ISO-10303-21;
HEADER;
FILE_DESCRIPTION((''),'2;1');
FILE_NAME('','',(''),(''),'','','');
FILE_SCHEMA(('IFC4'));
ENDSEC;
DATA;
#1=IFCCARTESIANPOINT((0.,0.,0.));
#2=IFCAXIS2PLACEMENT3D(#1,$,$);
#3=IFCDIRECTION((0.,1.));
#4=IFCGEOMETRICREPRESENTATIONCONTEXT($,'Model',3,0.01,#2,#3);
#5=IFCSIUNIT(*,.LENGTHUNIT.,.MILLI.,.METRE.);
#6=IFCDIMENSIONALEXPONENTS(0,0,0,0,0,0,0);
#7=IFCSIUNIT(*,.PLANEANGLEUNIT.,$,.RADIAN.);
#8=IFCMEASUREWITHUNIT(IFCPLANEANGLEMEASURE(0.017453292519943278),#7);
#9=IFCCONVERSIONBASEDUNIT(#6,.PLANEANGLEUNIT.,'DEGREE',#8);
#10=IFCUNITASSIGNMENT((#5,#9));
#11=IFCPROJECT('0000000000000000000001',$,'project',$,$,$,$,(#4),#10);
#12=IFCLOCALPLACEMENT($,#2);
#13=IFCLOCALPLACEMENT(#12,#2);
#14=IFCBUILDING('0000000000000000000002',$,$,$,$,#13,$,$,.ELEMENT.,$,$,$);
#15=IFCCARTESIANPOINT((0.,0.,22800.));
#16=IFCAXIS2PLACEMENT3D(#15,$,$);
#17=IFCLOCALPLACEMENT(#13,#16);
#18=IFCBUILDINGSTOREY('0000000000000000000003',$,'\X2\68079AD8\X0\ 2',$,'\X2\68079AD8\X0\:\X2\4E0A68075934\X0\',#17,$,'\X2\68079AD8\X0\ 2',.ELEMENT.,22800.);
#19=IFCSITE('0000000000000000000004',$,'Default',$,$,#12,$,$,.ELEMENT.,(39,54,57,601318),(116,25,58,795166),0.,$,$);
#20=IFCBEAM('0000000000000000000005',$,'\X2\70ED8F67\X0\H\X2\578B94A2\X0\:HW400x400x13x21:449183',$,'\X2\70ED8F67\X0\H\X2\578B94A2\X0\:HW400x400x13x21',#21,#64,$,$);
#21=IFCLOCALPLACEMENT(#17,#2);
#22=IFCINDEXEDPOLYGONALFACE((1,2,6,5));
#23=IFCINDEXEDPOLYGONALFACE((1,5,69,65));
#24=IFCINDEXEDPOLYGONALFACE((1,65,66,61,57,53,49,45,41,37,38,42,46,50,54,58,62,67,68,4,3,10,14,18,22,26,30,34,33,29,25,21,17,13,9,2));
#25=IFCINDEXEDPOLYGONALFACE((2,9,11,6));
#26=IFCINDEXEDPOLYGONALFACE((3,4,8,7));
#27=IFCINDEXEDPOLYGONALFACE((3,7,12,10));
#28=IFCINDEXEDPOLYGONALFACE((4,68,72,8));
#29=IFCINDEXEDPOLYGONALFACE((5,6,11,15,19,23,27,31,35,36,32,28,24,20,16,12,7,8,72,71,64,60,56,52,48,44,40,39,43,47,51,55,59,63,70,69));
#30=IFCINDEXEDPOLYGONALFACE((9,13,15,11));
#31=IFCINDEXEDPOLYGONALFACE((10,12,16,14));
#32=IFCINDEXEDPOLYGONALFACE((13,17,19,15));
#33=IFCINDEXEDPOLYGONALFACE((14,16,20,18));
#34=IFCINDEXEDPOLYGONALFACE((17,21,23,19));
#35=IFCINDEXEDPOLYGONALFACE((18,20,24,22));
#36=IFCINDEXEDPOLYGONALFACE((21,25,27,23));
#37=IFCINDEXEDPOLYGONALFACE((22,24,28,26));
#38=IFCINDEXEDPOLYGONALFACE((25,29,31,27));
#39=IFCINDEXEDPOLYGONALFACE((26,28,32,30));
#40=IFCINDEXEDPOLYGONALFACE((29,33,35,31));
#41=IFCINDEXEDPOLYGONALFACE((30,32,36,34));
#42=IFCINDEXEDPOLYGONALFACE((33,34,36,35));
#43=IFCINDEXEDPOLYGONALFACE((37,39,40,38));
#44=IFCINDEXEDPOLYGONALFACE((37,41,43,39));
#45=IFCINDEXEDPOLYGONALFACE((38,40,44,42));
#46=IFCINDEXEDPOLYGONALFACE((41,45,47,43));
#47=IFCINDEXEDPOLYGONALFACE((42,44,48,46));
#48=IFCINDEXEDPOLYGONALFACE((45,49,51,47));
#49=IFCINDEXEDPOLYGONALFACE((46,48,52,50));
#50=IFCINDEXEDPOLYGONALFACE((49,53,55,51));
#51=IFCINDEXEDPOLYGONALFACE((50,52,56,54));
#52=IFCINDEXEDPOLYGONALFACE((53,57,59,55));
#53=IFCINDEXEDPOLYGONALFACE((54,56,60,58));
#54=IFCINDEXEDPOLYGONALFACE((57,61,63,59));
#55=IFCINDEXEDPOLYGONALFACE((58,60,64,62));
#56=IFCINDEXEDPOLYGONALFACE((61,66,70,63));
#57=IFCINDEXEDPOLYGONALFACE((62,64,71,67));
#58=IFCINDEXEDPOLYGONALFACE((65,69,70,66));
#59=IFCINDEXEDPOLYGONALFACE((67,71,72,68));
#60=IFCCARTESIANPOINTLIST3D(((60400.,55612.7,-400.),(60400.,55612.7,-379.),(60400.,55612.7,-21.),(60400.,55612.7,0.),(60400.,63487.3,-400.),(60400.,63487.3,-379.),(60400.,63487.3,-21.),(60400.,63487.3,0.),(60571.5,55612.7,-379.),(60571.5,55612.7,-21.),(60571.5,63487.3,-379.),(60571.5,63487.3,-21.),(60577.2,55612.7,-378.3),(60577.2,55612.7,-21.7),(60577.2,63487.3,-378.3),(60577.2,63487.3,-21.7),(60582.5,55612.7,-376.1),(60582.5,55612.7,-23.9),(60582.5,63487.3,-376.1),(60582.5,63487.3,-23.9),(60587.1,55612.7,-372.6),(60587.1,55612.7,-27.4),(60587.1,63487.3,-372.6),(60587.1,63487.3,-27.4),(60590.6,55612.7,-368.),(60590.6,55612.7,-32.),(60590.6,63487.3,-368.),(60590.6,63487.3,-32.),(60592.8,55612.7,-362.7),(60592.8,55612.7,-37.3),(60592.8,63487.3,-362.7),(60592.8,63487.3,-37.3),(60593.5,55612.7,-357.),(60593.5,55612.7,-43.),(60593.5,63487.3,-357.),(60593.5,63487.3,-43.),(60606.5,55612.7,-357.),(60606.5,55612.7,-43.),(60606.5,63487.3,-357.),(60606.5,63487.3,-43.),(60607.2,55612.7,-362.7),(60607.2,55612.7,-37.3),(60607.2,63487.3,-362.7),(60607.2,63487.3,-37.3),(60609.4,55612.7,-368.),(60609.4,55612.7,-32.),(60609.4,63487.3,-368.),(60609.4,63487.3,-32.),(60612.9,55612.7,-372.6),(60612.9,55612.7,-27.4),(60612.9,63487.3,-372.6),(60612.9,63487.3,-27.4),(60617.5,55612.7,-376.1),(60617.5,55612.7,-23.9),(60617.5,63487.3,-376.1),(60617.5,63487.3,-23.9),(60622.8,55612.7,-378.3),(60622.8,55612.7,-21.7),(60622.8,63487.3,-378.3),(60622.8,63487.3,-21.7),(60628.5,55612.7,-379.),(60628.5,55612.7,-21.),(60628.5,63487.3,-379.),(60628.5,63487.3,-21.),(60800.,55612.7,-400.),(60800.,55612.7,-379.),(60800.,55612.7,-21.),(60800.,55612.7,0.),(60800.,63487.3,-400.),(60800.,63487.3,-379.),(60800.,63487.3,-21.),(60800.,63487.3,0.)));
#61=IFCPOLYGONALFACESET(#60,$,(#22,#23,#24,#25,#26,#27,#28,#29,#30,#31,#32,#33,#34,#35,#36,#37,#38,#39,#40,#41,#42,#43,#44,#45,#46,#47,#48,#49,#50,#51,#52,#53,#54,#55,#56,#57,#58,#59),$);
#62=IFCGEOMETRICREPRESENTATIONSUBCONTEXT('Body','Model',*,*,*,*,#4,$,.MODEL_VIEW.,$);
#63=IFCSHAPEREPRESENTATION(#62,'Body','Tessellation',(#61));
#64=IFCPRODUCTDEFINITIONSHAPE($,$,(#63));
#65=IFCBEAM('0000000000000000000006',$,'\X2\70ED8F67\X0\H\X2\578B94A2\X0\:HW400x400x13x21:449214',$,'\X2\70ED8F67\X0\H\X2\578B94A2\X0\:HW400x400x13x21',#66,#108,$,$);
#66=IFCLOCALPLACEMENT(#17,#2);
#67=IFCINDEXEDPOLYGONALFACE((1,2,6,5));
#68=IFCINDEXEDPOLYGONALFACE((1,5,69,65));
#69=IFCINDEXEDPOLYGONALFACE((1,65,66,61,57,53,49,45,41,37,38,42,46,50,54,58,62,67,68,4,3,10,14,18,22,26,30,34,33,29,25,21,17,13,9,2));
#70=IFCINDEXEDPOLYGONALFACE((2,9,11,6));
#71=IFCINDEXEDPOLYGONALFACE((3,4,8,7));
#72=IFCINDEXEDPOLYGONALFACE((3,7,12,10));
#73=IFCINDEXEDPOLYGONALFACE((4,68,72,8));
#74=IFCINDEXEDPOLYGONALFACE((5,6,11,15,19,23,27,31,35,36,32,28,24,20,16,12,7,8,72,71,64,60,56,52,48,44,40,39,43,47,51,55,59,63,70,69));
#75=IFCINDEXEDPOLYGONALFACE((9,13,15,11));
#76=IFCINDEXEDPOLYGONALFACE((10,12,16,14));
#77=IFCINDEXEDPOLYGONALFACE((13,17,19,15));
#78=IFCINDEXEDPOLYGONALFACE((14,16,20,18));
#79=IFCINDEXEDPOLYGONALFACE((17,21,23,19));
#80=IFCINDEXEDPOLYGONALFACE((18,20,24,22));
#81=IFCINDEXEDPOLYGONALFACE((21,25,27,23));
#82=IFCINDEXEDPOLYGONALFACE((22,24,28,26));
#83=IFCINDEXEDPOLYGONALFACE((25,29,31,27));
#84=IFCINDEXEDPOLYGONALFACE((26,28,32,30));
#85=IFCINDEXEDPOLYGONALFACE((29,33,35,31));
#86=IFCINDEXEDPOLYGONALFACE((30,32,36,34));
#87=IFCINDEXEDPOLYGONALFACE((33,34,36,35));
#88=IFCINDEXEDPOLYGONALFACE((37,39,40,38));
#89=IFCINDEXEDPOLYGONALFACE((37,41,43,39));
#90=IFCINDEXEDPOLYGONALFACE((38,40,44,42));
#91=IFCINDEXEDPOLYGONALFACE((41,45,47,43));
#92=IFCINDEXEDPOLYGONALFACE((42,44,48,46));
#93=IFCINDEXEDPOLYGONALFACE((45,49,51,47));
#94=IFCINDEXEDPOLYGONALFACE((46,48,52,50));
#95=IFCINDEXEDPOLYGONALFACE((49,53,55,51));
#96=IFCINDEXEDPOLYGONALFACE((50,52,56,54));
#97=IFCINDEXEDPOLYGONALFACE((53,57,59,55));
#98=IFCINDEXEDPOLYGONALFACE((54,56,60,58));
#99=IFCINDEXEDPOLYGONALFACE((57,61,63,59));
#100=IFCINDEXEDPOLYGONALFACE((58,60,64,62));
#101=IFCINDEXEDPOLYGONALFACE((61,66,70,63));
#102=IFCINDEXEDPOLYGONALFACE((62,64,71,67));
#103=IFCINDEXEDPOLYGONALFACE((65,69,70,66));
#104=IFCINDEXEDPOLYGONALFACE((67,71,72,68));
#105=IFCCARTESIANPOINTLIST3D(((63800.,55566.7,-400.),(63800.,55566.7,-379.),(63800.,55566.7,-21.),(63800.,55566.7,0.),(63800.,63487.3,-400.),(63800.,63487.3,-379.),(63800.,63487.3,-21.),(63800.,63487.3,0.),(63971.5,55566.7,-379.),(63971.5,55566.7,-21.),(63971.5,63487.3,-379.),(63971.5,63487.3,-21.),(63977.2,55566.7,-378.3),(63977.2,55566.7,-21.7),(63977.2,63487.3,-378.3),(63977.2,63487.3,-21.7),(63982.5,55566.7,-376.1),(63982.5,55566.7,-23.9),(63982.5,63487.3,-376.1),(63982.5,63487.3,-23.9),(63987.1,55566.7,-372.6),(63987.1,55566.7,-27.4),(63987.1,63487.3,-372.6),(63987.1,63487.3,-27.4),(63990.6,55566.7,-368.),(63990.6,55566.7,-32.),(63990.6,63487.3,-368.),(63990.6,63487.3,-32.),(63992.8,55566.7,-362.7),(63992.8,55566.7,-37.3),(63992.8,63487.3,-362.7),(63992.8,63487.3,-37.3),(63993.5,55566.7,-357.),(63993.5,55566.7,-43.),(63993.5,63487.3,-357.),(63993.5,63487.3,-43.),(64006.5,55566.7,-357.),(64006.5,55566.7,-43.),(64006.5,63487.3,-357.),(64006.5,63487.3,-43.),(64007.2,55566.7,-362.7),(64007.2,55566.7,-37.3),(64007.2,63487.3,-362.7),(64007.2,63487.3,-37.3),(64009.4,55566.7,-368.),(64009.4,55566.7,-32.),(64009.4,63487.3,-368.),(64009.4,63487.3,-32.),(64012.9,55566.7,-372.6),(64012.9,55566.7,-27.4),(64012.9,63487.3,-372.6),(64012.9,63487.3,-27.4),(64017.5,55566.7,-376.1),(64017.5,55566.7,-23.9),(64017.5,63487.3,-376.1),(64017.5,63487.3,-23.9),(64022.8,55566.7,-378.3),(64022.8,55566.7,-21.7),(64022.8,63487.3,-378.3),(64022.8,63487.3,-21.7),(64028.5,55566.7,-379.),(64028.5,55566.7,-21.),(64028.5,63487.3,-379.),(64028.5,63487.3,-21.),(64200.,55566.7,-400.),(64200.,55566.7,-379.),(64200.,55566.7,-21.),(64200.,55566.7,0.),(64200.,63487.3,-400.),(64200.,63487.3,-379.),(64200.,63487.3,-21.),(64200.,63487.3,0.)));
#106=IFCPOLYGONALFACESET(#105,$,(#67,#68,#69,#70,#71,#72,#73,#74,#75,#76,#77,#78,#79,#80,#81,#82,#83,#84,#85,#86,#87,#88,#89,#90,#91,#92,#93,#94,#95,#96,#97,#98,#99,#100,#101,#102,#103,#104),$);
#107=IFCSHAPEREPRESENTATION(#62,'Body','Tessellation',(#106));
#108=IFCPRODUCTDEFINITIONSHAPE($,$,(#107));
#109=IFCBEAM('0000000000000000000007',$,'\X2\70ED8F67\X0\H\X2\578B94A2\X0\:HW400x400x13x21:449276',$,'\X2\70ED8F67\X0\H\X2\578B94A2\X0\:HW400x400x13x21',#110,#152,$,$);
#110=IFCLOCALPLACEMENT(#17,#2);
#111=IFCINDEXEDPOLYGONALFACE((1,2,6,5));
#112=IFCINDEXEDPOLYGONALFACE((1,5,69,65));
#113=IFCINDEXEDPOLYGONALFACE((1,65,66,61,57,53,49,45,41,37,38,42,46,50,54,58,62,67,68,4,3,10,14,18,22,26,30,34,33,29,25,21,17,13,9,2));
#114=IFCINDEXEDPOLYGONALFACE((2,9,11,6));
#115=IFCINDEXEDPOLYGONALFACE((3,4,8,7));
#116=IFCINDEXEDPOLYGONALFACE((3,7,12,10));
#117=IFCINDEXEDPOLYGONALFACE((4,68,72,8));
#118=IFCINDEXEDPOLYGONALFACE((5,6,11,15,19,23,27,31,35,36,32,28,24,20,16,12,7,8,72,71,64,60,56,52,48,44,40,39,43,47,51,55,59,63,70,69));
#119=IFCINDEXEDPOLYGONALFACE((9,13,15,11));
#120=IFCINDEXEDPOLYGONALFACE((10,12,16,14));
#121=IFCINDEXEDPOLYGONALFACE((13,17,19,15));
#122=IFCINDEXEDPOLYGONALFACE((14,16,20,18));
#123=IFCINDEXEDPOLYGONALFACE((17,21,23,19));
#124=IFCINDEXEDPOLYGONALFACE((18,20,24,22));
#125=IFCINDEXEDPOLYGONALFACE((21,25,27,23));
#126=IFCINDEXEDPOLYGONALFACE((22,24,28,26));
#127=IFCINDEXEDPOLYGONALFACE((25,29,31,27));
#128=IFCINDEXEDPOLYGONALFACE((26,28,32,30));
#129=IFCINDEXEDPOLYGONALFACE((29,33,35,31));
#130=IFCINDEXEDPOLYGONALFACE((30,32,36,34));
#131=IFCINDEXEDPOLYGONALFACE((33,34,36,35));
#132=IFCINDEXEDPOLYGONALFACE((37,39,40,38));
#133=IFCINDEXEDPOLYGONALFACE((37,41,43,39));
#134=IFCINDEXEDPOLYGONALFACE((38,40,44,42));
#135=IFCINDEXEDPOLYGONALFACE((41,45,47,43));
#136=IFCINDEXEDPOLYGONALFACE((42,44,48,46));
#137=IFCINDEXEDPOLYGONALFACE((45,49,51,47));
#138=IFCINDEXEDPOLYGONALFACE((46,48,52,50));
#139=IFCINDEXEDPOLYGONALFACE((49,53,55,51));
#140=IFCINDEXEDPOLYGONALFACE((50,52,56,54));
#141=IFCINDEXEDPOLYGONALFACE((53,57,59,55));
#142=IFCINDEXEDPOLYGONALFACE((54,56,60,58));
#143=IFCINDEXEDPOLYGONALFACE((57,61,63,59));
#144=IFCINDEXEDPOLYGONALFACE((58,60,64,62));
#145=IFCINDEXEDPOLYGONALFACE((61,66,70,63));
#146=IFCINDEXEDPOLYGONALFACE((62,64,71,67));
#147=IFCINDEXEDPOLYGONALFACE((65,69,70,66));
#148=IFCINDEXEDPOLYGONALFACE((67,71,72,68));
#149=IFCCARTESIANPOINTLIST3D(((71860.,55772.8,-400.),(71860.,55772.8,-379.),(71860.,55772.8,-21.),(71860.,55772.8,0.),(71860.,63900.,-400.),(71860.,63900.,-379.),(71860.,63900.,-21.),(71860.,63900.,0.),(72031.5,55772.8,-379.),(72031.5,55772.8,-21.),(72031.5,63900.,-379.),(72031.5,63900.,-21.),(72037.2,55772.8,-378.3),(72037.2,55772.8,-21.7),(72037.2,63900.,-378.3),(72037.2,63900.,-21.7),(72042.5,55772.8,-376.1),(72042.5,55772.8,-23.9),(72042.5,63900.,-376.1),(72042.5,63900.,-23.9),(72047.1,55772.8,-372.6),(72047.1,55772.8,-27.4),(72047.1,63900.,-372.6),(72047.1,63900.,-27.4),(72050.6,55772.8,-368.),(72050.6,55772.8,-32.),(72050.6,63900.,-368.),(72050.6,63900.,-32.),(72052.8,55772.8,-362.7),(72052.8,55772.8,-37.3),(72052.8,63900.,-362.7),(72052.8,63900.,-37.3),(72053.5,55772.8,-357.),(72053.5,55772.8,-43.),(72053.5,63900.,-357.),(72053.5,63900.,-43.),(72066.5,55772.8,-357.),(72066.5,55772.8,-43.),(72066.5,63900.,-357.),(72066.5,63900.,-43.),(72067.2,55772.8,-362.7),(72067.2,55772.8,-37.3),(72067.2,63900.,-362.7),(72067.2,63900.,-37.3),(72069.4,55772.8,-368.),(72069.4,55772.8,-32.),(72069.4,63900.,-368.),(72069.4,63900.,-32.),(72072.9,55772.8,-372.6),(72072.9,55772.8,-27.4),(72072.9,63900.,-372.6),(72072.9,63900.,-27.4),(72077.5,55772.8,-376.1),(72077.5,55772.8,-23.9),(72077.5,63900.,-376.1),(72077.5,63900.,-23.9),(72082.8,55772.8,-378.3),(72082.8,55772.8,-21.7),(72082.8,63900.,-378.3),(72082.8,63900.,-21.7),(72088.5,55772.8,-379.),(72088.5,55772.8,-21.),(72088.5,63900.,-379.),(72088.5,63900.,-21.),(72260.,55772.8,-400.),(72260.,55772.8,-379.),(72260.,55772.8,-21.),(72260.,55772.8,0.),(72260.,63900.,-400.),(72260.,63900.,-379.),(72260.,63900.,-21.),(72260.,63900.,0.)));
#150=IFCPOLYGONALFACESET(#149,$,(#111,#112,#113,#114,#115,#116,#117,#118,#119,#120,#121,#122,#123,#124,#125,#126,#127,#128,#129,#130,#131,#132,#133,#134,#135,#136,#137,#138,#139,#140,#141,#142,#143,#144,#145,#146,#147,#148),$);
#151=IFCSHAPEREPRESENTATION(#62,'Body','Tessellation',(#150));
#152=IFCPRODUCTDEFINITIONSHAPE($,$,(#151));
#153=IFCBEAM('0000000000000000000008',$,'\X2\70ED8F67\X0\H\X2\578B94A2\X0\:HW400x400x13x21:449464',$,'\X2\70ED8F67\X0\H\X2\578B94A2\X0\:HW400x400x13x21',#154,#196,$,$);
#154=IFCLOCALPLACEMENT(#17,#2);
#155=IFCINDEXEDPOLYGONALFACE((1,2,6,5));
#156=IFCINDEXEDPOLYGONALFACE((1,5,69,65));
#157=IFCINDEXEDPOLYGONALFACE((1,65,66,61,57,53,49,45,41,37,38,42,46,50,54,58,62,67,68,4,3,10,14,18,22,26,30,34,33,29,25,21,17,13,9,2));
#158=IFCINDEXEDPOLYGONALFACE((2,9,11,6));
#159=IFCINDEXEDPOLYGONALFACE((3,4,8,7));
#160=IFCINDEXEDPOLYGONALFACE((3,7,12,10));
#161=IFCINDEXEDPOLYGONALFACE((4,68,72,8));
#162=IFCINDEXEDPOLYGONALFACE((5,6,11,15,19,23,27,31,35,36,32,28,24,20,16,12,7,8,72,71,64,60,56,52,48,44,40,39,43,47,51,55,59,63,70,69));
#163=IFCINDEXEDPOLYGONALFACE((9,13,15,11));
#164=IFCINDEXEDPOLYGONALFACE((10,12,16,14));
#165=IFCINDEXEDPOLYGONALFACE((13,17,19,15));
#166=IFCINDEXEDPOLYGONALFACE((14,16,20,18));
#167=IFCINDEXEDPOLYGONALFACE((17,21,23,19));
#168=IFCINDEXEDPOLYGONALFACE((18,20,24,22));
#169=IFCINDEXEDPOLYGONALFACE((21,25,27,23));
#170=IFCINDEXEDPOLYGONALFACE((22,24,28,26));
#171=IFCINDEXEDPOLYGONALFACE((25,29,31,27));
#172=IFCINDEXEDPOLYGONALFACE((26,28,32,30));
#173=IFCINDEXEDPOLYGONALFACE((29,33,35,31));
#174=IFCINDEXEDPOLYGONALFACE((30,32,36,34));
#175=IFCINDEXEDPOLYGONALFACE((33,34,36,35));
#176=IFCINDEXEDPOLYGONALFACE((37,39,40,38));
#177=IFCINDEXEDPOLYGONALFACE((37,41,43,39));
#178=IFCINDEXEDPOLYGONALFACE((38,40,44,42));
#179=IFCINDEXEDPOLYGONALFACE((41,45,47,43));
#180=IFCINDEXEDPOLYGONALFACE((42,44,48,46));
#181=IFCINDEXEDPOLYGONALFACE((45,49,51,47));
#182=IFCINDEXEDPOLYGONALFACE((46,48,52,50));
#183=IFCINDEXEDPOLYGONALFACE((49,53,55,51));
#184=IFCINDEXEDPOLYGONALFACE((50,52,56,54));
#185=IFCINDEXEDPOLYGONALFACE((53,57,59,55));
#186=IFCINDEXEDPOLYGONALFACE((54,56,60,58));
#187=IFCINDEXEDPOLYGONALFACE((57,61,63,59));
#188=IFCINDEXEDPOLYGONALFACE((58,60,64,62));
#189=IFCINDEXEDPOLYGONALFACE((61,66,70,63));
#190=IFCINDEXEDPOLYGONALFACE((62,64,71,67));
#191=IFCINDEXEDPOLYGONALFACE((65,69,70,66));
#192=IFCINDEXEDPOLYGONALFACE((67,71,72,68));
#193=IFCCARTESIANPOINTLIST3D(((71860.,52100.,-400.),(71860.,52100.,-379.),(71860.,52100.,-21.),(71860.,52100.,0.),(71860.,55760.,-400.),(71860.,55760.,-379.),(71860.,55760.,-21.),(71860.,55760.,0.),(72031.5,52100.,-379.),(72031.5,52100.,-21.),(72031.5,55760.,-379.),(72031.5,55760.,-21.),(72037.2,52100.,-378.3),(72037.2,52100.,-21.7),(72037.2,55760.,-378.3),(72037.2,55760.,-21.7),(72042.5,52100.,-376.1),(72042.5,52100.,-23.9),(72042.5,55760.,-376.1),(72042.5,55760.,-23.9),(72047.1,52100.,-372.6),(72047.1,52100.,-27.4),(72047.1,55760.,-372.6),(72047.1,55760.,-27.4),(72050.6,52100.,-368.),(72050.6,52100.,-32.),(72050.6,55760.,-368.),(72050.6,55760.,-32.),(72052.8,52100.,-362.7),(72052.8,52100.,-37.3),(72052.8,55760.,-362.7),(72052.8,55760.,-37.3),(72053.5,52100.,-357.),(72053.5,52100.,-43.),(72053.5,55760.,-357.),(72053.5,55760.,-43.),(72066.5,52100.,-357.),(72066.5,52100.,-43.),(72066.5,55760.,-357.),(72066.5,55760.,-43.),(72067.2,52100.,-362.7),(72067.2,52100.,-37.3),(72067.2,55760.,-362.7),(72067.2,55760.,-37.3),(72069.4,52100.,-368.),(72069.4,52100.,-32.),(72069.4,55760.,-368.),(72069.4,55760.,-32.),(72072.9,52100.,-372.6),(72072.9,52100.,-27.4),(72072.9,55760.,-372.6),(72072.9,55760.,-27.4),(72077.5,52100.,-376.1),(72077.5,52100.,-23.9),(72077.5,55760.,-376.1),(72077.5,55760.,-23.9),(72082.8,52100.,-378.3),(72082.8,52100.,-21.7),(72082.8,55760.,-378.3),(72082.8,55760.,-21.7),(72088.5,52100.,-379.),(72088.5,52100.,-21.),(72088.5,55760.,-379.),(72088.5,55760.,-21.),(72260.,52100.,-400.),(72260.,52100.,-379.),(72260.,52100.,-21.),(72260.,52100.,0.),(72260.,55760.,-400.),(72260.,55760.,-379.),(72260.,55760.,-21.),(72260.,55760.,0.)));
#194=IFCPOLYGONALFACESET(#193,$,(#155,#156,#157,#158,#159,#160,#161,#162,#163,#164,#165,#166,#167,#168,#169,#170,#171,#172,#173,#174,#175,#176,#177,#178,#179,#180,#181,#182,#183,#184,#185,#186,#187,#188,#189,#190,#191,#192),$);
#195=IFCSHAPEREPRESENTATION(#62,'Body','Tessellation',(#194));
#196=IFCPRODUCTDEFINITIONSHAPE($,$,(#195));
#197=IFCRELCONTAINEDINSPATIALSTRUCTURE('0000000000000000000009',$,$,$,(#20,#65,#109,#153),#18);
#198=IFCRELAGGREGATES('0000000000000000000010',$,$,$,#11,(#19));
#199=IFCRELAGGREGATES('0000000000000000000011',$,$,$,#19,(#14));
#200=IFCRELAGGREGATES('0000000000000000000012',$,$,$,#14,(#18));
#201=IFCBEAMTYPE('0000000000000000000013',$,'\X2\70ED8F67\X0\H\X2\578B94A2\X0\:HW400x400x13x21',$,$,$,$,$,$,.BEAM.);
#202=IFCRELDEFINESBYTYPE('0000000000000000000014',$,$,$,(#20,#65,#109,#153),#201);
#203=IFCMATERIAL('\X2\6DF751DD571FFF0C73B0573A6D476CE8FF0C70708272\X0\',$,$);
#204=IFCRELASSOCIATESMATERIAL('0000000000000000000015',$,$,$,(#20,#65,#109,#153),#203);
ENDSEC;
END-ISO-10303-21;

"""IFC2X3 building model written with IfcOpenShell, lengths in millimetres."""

from ifc_helpers import new_model, entity, si_unit, converted_unit, direction, frame, frame_2d, origin, place, context, subcontext, project, spatial, i_section, extrude, material, type_object, element, save


model = new_model("IFC2X3")

# Units and contexts
model_context = context("Model", 3, precision=0.01, world=origin(), true_north=direction((0.0, 1.0)))
body_context = subcontext(model_context, "Body", "Model", "MODEL_VIEW")
ifc_project = project(units=[si_unit("LENGTHUNIT", "METRE", prefix="MILLI"), converted_unit("PLANEANGLEUNIT", "DEGREE", entity("IfcPlaneAngleMeasure", 0.017453292519943278), si_unit("PLANEANGLEUNIT", "RADIAN"), dimensions=[0, 0, 0, 0, 0, 0, 0])], contexts=[model_context])

# Site, building, storey
site_placement = place(None, origin())
site = spatial("IfcSite", under=ifc_project, at=site_placement, Name="Default", CompositionType="ELEMENT", RefLatitude=(39, 54, 57, 601318), RefLongitude=(116, 25, 58, 795166), RefElevation=0.0)
building_placement = place(site_placement, origin())
building = spatial("IfcBuilding", under=site, at=building_placement, CompositionType="ELEMENT")
storey_placement = place(building_placement, frame((0.0, 0.0, 22800.0)))
storey = spatial("IfcBuildingStorey", under=building, at=storey_placement, Name="标高 2", ObjectType="标高:上标头", LongName="标高 2", CompositionType="ELEMENT", Elevation=22800.0)

# Beams
ifc_material = material(Name="混凝土，现场浇注，灰色")
beam_type = type_object("IfcBeamType", Name="热轧H型钢:HW400x400x13x21", PredefinedType="BEAM")
beam_1_placement = place(storey_placement, frame((60600.0, 63700.0, 0.0), z_axis=(0.0, 0.0, 1.0), x_axis=(0.0, -1.0, 0.0)))
element("IfcBeam", 1, at=beam_1_placement, inside=storey, type_object=beam_type, material=ifc_material, Name="热轧H型钢:HW400x400x13x21:449183", ObjectType="热轧H型钢:HW400x400x13x21", context=body_context, shape_type="SweptSolid", body=[
    extrude(i_section(OverallWidth=400.0, OverallDepth=400.0, WebThickness=13.0, FlangeThickness=21.0, FilletRadius=22.0, at=frame_2d((0.0, 0.0), x_axis=(0.0, 1.0))), frame((212.7, 0.0, -200.0), z_axis=(1.0, 0.0, 0.0), x_axis=(0.0, 0.0, -1.0)), (0.0, 0.0, 1.0), 7874.6),
])
beam_2_placement = place(storey_placement, frame((64000.0, 63700.0, 0.0), z_axis=(0.0, 0.0, 1.0), x_axis=(0.0, -1.0, 0.0)))
element("IfcBeam", 2, at=beam_2_placement, inside=storey, type_object=beam_type, material=ifc_material, Name="热轧H型钢:HW400x400x13x21:449214", ObjectType="热轧H型钢:HW400x400x13x21", context=body_context, shape_type="SweptSolid", body=[
    extrude(i_section(OverallWidth=400.0, OverallDepth=400.0, WebThickness=13.0, FlangeThickness=21.0, FilletRadius=22.0, at=frame_2d((0.0, 0.0), x_axis=(0.0, 1.0))), frame((212.7, 0.0, -200.0), z_axis=(1.0, 0.0, 0.0), x_axis=(0.0, 0.0, -1.0)), (0.0, 0.0, 1.0), 7920.6),
])
beam_3_placement = place(storey_placement, frame((72060.0, 63700.0, 0.0), z_axis=(0.0, 0.0, 1.0), x_axis=(0.0, -1.0, 0.0)))
element("IfcBeam", 3, at=beam_3_placement, inside=storey, type_object=beam_type, material=ifc_material, Name="热轧H型钢:HW400x400x13x21:449276", ObjectType="热轧H型钢:HW400x400x13x21", context=body_context, shape_type="SweptSolid", body=[
    extrude(i_section(OverallWidth=400.0, OverallDepth=400.0, WebThickness=13.0, FlangeThickness=21.0, FilletRadius=22.0, at=frame_2d((0.0, 0.0), x_axis=(0.0, 1.0))), frame((-200.0, 0.0, -200.0), z_axis=(1.0, 0.0, 0.0), x_axis=(0.0, 0.0, -1.0)), (0.0, 0.0, 1.0), 8127.2),
])
beam_4_placement = place(storey_placement, frame((72060.0, 55760.0, 0.0), z_axis=(0.0, 0.0, 1.0), x_axis=(0.0, -1.0, 0.0)))
element("IfcBeam", 4, at=beam_4_placement, inside=storey, type_object=beam_type, material=ifc_material, Name="热轧H型钢:HW400x400x13x21:449464", ObjectType="热轧H型钢:HW400x400x13x21", context=body_context, shape_type="SweptSolid", body=[
    extrude(i_section(OverallWidth=400.0, OverallDepth=400.0, WebThickness=13.0, FlangeThickness=21.0, FilletRadius=22.0, at=frame_2d((0.0, 0.0), x_axis=(0.0, 1.0))), frame((0.0, 0.0, -200.0), z_axis=(1.0, 0.0, 0.0), x_axis=(0.0, 0.0, -1.0)), (0.0, 0.0, 1.0), 3660.0),
])

save(model, "model.ifc")
